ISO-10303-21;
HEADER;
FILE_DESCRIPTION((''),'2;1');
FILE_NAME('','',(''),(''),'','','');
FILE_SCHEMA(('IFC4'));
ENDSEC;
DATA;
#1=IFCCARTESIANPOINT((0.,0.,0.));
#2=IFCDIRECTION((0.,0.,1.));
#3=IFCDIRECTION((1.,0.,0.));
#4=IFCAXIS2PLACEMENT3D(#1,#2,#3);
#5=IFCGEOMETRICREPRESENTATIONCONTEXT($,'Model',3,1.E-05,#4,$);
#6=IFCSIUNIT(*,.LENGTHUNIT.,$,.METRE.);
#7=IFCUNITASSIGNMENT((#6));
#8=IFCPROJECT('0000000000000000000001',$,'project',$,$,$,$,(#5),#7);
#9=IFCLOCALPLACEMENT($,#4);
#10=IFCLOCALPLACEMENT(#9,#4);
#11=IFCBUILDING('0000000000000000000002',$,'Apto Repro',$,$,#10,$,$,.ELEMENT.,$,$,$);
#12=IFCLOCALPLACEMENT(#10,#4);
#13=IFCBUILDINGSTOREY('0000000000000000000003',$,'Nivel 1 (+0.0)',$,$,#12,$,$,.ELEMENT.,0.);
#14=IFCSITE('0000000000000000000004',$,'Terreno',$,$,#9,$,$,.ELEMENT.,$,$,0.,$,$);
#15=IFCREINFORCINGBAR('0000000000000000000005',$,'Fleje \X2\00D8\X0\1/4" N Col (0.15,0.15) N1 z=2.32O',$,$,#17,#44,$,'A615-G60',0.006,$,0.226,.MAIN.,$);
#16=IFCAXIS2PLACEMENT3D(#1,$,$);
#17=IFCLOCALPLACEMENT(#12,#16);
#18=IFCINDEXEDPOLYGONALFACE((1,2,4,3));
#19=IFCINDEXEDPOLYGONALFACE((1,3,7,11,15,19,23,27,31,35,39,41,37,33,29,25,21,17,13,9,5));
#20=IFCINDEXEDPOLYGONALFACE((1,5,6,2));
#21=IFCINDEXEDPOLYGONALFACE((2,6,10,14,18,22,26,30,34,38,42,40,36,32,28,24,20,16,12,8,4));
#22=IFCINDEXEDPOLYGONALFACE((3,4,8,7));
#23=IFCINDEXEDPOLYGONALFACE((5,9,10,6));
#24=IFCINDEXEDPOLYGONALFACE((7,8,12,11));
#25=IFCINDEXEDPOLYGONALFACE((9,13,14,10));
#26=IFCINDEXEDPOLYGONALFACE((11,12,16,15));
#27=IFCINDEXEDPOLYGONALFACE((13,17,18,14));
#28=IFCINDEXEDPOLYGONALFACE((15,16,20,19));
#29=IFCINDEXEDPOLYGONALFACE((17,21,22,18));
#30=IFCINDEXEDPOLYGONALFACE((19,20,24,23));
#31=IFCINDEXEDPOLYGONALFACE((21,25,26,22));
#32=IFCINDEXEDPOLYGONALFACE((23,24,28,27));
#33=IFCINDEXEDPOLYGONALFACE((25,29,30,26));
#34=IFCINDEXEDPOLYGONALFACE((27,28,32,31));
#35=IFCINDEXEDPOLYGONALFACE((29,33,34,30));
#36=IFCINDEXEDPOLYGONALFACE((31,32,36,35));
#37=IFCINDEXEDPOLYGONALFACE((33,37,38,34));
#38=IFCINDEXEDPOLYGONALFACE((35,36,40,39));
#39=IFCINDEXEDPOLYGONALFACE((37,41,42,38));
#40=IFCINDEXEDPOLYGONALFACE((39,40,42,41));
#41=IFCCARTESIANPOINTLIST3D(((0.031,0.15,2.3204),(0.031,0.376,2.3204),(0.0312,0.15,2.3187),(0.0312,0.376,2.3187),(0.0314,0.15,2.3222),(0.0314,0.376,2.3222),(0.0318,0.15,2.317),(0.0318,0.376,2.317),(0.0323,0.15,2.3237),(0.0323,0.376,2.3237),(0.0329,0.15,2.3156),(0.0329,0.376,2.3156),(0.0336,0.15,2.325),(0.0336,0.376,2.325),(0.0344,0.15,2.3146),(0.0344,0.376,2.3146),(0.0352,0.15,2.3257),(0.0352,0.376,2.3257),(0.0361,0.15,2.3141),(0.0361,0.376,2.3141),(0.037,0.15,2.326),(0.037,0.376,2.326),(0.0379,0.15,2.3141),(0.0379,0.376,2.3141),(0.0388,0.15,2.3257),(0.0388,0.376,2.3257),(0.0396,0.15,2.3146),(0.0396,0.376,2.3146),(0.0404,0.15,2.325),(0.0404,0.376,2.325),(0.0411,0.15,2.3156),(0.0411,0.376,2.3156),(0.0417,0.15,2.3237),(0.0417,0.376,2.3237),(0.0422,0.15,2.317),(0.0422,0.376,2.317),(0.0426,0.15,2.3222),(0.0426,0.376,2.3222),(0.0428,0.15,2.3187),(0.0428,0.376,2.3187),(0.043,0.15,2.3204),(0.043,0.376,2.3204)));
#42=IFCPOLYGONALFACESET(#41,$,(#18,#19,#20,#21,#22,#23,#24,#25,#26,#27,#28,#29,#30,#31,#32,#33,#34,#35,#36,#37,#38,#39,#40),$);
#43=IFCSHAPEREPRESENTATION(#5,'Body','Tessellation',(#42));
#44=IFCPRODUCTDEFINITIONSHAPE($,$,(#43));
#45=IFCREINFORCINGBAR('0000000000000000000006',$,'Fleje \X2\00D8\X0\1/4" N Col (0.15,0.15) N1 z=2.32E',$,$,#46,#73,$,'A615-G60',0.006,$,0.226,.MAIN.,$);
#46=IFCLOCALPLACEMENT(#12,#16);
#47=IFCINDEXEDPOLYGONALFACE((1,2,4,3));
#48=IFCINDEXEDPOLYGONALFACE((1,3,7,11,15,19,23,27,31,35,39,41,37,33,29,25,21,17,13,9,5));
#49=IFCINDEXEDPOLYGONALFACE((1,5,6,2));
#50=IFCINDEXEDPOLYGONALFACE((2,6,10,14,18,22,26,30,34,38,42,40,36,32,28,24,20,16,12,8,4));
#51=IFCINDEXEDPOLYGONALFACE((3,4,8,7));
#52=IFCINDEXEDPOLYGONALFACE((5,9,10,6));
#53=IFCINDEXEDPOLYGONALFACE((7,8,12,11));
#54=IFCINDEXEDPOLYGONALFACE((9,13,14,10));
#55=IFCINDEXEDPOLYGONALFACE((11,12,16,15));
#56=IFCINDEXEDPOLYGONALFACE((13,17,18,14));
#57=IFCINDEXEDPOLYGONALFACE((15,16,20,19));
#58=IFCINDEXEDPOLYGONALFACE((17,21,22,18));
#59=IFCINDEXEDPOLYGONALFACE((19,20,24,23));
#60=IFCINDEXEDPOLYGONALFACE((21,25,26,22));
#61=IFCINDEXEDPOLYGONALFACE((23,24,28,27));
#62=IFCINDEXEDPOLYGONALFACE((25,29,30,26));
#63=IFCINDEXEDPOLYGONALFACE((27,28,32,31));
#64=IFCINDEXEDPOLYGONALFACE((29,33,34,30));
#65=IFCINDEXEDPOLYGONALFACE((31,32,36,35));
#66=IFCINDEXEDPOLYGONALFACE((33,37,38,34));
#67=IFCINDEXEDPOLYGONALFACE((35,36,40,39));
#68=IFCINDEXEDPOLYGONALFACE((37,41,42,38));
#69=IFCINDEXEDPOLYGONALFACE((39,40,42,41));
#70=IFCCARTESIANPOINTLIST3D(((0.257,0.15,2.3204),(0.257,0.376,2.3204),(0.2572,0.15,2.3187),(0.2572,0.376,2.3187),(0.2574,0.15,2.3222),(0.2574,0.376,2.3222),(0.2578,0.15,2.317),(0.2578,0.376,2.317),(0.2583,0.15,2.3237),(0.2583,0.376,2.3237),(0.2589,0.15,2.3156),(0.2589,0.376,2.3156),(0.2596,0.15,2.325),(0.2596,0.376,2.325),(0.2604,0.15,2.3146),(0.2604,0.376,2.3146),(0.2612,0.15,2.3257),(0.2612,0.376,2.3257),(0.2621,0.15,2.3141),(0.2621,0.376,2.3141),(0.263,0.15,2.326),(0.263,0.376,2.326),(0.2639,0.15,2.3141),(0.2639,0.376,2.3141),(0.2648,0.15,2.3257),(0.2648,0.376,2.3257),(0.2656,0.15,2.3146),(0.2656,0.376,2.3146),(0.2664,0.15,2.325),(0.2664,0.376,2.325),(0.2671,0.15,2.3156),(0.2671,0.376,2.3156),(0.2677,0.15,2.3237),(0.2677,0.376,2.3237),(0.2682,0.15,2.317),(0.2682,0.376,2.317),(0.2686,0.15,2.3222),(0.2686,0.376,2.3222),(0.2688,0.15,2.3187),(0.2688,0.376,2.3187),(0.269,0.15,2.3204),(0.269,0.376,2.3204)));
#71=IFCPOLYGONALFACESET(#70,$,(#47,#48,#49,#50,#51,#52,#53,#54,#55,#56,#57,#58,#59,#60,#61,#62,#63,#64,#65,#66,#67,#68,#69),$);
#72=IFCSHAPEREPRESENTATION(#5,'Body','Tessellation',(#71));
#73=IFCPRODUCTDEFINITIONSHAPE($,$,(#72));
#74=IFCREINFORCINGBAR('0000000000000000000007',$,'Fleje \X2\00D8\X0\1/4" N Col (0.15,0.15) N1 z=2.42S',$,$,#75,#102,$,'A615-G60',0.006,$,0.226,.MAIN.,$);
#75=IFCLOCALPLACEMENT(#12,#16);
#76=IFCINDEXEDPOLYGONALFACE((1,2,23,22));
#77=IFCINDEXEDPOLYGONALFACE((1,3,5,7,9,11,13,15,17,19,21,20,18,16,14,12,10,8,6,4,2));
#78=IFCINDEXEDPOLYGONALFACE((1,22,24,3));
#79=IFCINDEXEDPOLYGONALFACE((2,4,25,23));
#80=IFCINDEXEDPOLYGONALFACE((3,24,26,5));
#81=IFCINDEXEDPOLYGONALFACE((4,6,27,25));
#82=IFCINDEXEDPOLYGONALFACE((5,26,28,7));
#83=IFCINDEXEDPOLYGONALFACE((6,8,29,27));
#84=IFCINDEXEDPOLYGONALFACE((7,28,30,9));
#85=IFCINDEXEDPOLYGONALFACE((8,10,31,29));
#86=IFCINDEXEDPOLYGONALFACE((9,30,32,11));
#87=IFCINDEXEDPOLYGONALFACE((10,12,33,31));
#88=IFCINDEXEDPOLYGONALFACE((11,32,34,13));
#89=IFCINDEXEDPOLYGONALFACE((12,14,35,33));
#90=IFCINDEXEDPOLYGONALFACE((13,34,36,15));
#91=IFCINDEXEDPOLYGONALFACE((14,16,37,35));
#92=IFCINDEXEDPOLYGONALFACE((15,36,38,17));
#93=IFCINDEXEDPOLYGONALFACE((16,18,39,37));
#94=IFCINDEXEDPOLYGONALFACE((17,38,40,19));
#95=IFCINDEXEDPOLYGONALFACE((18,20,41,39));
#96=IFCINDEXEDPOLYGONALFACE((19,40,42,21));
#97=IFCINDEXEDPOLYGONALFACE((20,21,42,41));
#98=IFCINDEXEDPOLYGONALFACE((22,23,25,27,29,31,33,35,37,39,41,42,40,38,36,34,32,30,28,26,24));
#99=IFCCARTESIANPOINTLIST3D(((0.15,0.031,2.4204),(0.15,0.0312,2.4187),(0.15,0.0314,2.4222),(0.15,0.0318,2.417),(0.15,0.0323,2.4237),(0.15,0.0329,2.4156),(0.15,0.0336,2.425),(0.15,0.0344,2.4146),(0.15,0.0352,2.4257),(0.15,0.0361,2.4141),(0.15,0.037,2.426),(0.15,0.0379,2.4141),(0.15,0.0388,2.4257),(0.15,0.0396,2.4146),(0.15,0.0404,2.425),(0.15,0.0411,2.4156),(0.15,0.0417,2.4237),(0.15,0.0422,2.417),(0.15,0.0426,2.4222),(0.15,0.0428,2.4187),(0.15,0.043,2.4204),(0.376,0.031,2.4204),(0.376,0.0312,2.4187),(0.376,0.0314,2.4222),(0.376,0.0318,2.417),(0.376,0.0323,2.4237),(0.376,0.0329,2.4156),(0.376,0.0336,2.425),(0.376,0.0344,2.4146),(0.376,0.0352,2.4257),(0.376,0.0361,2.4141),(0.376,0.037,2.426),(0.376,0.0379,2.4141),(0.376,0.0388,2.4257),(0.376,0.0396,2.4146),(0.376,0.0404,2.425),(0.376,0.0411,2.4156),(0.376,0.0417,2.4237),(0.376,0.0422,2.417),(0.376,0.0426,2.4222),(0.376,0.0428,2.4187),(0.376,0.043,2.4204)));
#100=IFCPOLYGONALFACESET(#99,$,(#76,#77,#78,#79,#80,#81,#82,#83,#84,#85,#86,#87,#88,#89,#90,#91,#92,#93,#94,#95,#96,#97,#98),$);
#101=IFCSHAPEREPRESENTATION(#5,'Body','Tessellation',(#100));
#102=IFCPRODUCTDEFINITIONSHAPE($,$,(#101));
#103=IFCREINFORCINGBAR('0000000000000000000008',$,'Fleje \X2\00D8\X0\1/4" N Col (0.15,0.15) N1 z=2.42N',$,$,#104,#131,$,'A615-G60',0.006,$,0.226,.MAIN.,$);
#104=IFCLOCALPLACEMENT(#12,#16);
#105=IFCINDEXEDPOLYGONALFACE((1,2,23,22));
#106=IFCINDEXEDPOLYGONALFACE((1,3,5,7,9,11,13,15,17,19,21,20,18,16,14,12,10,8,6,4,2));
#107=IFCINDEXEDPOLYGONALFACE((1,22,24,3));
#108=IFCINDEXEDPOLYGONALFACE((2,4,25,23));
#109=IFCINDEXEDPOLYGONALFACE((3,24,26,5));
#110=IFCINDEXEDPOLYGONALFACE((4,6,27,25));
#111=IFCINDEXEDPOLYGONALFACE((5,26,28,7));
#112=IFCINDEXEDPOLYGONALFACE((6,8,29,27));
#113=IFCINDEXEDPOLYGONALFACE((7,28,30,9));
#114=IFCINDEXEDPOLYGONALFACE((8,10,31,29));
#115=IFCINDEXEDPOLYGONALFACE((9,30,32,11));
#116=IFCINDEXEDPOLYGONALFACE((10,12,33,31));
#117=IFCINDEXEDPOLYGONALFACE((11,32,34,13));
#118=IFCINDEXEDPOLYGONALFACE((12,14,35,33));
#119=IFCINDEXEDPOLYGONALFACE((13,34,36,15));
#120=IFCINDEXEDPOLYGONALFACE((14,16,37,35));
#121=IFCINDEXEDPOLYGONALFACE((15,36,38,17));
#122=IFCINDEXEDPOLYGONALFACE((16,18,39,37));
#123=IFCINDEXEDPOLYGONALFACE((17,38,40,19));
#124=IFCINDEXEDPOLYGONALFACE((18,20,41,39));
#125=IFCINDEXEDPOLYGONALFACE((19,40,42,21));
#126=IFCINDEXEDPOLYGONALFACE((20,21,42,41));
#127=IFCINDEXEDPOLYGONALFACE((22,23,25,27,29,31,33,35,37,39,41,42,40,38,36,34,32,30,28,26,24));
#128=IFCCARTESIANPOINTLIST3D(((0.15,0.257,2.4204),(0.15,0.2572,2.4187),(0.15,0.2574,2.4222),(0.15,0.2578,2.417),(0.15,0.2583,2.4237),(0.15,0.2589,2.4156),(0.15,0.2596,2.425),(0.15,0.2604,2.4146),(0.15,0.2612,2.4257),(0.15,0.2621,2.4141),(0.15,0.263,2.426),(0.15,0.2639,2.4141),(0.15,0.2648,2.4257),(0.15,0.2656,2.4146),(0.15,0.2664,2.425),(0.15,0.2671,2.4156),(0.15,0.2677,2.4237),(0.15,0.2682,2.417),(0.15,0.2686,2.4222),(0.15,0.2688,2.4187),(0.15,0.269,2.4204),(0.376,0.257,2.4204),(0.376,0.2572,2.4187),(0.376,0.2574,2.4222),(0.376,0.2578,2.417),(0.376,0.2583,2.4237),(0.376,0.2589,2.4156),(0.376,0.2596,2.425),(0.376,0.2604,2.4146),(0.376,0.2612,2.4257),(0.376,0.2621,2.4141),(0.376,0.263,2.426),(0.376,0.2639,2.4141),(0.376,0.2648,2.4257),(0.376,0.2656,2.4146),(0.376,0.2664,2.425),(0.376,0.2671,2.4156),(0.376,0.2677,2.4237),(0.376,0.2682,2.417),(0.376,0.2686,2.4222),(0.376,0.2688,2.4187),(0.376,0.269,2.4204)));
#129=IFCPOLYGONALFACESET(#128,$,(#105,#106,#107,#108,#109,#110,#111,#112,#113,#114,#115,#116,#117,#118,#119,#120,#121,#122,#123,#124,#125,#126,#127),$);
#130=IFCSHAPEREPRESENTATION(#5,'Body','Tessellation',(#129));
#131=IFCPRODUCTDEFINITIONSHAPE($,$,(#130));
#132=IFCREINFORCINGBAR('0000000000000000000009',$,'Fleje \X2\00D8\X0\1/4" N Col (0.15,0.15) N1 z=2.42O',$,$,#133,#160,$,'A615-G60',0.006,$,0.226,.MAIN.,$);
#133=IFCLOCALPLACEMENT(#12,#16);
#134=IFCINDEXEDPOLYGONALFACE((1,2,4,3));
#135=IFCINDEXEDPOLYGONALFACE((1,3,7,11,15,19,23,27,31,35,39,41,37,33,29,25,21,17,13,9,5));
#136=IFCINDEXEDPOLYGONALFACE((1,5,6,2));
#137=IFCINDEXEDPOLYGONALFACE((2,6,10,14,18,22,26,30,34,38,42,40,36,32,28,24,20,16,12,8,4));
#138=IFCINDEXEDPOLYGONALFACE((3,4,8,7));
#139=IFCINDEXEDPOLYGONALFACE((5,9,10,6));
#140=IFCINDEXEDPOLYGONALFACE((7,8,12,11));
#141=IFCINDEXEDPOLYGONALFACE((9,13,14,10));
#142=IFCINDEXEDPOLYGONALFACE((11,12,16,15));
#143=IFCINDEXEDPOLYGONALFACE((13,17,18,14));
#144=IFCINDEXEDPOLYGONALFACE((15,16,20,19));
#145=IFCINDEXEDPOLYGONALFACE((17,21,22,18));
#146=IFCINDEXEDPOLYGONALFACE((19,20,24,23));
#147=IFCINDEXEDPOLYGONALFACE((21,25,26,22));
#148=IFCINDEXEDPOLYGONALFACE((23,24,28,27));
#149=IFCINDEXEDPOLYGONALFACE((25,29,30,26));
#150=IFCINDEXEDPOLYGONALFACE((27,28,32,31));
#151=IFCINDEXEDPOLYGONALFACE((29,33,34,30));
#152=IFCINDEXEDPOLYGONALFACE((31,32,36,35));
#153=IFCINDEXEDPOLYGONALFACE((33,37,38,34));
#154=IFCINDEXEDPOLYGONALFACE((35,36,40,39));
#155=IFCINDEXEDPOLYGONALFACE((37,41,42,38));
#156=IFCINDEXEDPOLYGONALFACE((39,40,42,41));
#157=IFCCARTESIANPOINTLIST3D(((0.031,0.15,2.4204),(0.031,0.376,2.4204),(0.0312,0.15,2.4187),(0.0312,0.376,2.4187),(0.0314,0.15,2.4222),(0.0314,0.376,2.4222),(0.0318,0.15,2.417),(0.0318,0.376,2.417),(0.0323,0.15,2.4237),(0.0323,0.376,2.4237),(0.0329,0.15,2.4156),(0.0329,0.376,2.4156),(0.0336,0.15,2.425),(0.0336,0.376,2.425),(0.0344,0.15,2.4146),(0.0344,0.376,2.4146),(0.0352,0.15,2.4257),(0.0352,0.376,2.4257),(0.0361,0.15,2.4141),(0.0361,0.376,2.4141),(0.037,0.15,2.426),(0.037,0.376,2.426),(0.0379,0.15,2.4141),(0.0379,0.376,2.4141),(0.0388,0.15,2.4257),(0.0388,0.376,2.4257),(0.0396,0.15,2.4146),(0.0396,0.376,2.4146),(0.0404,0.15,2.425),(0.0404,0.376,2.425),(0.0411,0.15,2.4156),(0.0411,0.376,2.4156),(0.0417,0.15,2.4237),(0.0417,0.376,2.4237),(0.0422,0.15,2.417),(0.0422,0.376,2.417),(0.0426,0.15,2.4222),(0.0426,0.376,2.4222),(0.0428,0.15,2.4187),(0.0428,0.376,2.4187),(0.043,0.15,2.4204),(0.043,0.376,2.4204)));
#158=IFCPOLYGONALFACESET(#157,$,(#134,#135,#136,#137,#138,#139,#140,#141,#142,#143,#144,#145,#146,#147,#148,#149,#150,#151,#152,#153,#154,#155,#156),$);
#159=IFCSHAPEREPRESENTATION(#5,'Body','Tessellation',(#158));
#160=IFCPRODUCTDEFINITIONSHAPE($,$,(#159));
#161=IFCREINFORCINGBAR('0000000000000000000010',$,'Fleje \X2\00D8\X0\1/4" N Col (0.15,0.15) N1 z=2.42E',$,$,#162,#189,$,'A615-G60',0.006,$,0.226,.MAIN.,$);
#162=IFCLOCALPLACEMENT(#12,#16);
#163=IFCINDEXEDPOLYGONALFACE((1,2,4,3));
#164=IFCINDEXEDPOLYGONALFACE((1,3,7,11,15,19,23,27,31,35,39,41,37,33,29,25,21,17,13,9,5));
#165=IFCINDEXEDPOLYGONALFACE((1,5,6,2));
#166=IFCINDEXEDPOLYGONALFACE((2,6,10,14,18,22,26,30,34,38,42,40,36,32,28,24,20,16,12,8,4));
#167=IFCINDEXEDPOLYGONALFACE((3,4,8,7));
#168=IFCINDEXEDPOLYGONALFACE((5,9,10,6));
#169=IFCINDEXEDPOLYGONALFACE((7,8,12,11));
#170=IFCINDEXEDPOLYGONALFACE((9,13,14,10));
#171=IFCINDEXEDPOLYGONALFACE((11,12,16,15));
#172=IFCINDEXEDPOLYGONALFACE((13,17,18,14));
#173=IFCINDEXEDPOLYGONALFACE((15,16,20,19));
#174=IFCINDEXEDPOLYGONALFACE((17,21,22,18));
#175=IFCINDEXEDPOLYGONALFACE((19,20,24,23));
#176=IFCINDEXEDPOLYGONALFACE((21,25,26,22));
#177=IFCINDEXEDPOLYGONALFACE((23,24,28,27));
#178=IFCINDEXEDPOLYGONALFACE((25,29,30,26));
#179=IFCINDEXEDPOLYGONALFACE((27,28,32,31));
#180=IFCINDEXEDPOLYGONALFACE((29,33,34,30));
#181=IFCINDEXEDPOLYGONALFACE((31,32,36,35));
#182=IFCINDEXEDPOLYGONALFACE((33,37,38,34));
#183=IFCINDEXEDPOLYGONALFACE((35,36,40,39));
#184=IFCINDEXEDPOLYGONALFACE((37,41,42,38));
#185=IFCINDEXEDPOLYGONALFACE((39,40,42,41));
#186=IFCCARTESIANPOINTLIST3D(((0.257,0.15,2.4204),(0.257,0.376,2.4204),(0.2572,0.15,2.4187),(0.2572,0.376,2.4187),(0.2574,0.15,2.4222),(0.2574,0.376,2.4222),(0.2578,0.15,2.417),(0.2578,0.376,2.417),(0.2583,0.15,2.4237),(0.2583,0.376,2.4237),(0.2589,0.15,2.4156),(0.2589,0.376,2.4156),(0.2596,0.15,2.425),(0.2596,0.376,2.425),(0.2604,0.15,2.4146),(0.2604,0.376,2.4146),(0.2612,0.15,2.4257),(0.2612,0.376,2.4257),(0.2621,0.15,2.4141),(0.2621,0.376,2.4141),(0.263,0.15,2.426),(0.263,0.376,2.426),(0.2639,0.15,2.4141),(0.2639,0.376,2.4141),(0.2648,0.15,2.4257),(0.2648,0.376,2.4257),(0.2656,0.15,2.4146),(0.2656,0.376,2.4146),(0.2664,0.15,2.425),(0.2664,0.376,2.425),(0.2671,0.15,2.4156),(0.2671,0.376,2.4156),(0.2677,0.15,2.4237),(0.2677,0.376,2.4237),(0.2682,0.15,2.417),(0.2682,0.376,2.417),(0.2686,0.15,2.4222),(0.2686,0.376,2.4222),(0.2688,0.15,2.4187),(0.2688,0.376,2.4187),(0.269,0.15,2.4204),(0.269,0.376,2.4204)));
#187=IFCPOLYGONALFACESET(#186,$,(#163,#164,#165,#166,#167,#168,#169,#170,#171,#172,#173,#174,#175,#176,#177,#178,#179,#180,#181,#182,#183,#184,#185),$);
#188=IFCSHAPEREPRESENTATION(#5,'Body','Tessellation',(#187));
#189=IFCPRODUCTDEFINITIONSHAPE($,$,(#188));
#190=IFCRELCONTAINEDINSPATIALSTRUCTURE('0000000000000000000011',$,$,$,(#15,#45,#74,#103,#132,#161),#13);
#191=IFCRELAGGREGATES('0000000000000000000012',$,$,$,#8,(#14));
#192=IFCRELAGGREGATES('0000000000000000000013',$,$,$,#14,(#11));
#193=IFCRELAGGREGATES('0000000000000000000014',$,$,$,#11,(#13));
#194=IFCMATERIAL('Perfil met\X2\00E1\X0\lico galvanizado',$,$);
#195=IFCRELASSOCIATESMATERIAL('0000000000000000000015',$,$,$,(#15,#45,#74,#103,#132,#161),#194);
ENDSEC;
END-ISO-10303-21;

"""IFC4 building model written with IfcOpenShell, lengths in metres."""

from ifc_helpers import new_model, si_unit, frame, origin_with_axes, origin_2d_with_axis, place, context, project, spatial, circle, extrude, material, element, save


model = new_model("IFC4")

# Units and contexts
model_context = context("Model", 3, precision=1e-05, world=origin_with_axes())
ifc_project = project(units=[si_unit("LENGTHUNIT", "METRE")], contexts=[model_context])

# Site, building, storey
site_placement = place(None, origin_with_axes())
site = spatial("IfcSite", under=ifc_project, at=site_placement, Name="Terreno", CompositionType="ELEMENT", RefElevation=0.0)
building_placement = place(site_placement, origin_with_axes())
building = spatial("IfcBuilding", under=site, at=building_placement, Name="Apto Repro", CompositionType="ELEMENT")
storey_placement = place(building_placement, origin_with_axes())
storey = spatial("IfcBuildingStorey", under=building, at=storey_placement, Name="Nivel 1 (+0.0)", CompositionType="ELEMENT", Elevation=0.0)

# Reinforcing bars
ifc_material = material(Name="Perfil metálico galvanizado")
reinforcing_bar_1_placement = place(storey_placement, origin_with_axes())
element("IfcReinforcingBar", 1, at=reinforcing_bar_1_placement, inside=storey, material=ifc_material, Name="Fleje Ø1/4\" N Col (0.15,0.15) N1 z=2.32O", SteelGrade="A615-G60", BarLength=0.226, NominalDiameter=0.006, PredefinedType="MAIN", context=model_context, shape_type="SweptSolid", body=[
    extrude(circle(Radius=0.006, at=origin_2d_with_axis()), frame((0.037, 0.15, 2.32), z_axis=(0.0, 1.0, 0.0), x_axis=(0.0, 0.0, 1.0)), (0.0, 0.0, 1.0), 0.226),
])
reinforcing_bar_2_placement = place(storey_placement, origin_with_axes())
element("IfcReinforcingBar", 2, at=reinforcing_bar_2_placement, inside=storey, material=ifc_material, Name="Fleje Ø1/4\" N Col (0.15,0.15) N1 z=2.32E", SteelGrade="A615-G60", BarLength=0.226, NominalDiameter=0.006, PredefinedType="MAIN", context=model_context, shape_type="SweptSolid", body=[
    extrude(circle(Radius=0.006, at=origin_2d_with_axis()), frame((0.263, 0.15, 2.32), z_axis=(0.0, 1.0, 0.0), x_axis=(0.0, 0.0, 1.0)), (0.0, 0.0, 1.0), 0.226),
])
reinforcing_bar_3_placement = place(storey_placement, origin_with_axes())
element("IfcReinforcingBar", 3, at=reinforcing_bar_3_placement, inside=storey, material=ifc_material, Name="Fleje Ø1/4\" N Col (0.15,0.15) N1 z=2.42S", SteelGrade="A615-G60", BarLength=0.226, NominalDiameter=0.006, PredefinedType="MAIN", context=model_context, shape_type="SweptSolid", body=[
    extrude(circle(Radius=0.006, at=origin_2d_with_axis()), frame((0.15, 0.037, 2.42), z_axis=(1.0, 0.0, 0.0), x_axis=(0.0, 0.0, 1.0)), (0.0, 0.0, 1.0), 0.226),
])
reinforcing_bar_4_placement = place(storey_placement, origin_with_axes())
element("IfcReinforcingBar", 4, at=reinforcing_bar_4_placement, inside=storey, material=ifc_material, Name="Fleje Ø1/4\" N Col (0.15,0.15) N1 z=2.42N", SteelGrade="A615-G60", BarLength=0.226, NominalDiameter=0.006, PredefinedType="MAIN", context=model_context, shape_type="SweptSolid", body=[
    extrude(circle(Radius=0.006, at=origin_2d_with_axis()), frame((0.15, 0.263, 2.42), z_axis=(1.0, 0.0, 0.0), x_axis=(0.0, 0.0, 1.0)), (0.0, 0.0, 1.0), 0.226),
])
reinforcing_bar_5_placement = place(storey_placement, origin_with_axes())
element("IfcReinforcingBar", 5, at=reinforcing_bar_5_placement, inside=storey, material=ifc_material, Name="Fleje Ø1/4\" N Col (0.15,0.15) N1 z=2.42O", SteelGrade="A615-G60", BarLength=0.226, NominalDiameter=0.006, PredefinedType="MAIN", context=model_context, shape_type="SweptSolid", body=[
    extrude(circle(Radius=0.006, at=origin_2d_with_axis()), frame((0.037, 0.15, 2.42), z_axis=(0.0, 1.0, 0.0), x_axis=(0.0, 0.0, 1.0)), (0.0, 0.0, 1.0), 0.226),
])
reinforcing_bar_6_placement = place(storey_placement, origin_with_axes())
element("IfcReinforcingBar", 6, at=reinforcing_bar_6_placement, inside=storey, material=ifc_material, Name="Fleje Ø1/4\" N Col (0.15,0.15) N1 z=2.42E", SteelGrade="A615-G60", BarLength=0.226, NominalDiameter=0.006, PredefinedType="MAIN", context=model_context, shape_type="SweptSolid", body=[
    extrude(circle(Radius=0.006, at=origin_2d_with_axis()), frame((0.263, 0.15, 2.42), z_axis=(0.0, 1.0, 0.0), x_axis=(0.0, 0.0, 1.0)), (0.0, 0.0, 1.0), 0.226),
])

save(model, "model.ifc")
